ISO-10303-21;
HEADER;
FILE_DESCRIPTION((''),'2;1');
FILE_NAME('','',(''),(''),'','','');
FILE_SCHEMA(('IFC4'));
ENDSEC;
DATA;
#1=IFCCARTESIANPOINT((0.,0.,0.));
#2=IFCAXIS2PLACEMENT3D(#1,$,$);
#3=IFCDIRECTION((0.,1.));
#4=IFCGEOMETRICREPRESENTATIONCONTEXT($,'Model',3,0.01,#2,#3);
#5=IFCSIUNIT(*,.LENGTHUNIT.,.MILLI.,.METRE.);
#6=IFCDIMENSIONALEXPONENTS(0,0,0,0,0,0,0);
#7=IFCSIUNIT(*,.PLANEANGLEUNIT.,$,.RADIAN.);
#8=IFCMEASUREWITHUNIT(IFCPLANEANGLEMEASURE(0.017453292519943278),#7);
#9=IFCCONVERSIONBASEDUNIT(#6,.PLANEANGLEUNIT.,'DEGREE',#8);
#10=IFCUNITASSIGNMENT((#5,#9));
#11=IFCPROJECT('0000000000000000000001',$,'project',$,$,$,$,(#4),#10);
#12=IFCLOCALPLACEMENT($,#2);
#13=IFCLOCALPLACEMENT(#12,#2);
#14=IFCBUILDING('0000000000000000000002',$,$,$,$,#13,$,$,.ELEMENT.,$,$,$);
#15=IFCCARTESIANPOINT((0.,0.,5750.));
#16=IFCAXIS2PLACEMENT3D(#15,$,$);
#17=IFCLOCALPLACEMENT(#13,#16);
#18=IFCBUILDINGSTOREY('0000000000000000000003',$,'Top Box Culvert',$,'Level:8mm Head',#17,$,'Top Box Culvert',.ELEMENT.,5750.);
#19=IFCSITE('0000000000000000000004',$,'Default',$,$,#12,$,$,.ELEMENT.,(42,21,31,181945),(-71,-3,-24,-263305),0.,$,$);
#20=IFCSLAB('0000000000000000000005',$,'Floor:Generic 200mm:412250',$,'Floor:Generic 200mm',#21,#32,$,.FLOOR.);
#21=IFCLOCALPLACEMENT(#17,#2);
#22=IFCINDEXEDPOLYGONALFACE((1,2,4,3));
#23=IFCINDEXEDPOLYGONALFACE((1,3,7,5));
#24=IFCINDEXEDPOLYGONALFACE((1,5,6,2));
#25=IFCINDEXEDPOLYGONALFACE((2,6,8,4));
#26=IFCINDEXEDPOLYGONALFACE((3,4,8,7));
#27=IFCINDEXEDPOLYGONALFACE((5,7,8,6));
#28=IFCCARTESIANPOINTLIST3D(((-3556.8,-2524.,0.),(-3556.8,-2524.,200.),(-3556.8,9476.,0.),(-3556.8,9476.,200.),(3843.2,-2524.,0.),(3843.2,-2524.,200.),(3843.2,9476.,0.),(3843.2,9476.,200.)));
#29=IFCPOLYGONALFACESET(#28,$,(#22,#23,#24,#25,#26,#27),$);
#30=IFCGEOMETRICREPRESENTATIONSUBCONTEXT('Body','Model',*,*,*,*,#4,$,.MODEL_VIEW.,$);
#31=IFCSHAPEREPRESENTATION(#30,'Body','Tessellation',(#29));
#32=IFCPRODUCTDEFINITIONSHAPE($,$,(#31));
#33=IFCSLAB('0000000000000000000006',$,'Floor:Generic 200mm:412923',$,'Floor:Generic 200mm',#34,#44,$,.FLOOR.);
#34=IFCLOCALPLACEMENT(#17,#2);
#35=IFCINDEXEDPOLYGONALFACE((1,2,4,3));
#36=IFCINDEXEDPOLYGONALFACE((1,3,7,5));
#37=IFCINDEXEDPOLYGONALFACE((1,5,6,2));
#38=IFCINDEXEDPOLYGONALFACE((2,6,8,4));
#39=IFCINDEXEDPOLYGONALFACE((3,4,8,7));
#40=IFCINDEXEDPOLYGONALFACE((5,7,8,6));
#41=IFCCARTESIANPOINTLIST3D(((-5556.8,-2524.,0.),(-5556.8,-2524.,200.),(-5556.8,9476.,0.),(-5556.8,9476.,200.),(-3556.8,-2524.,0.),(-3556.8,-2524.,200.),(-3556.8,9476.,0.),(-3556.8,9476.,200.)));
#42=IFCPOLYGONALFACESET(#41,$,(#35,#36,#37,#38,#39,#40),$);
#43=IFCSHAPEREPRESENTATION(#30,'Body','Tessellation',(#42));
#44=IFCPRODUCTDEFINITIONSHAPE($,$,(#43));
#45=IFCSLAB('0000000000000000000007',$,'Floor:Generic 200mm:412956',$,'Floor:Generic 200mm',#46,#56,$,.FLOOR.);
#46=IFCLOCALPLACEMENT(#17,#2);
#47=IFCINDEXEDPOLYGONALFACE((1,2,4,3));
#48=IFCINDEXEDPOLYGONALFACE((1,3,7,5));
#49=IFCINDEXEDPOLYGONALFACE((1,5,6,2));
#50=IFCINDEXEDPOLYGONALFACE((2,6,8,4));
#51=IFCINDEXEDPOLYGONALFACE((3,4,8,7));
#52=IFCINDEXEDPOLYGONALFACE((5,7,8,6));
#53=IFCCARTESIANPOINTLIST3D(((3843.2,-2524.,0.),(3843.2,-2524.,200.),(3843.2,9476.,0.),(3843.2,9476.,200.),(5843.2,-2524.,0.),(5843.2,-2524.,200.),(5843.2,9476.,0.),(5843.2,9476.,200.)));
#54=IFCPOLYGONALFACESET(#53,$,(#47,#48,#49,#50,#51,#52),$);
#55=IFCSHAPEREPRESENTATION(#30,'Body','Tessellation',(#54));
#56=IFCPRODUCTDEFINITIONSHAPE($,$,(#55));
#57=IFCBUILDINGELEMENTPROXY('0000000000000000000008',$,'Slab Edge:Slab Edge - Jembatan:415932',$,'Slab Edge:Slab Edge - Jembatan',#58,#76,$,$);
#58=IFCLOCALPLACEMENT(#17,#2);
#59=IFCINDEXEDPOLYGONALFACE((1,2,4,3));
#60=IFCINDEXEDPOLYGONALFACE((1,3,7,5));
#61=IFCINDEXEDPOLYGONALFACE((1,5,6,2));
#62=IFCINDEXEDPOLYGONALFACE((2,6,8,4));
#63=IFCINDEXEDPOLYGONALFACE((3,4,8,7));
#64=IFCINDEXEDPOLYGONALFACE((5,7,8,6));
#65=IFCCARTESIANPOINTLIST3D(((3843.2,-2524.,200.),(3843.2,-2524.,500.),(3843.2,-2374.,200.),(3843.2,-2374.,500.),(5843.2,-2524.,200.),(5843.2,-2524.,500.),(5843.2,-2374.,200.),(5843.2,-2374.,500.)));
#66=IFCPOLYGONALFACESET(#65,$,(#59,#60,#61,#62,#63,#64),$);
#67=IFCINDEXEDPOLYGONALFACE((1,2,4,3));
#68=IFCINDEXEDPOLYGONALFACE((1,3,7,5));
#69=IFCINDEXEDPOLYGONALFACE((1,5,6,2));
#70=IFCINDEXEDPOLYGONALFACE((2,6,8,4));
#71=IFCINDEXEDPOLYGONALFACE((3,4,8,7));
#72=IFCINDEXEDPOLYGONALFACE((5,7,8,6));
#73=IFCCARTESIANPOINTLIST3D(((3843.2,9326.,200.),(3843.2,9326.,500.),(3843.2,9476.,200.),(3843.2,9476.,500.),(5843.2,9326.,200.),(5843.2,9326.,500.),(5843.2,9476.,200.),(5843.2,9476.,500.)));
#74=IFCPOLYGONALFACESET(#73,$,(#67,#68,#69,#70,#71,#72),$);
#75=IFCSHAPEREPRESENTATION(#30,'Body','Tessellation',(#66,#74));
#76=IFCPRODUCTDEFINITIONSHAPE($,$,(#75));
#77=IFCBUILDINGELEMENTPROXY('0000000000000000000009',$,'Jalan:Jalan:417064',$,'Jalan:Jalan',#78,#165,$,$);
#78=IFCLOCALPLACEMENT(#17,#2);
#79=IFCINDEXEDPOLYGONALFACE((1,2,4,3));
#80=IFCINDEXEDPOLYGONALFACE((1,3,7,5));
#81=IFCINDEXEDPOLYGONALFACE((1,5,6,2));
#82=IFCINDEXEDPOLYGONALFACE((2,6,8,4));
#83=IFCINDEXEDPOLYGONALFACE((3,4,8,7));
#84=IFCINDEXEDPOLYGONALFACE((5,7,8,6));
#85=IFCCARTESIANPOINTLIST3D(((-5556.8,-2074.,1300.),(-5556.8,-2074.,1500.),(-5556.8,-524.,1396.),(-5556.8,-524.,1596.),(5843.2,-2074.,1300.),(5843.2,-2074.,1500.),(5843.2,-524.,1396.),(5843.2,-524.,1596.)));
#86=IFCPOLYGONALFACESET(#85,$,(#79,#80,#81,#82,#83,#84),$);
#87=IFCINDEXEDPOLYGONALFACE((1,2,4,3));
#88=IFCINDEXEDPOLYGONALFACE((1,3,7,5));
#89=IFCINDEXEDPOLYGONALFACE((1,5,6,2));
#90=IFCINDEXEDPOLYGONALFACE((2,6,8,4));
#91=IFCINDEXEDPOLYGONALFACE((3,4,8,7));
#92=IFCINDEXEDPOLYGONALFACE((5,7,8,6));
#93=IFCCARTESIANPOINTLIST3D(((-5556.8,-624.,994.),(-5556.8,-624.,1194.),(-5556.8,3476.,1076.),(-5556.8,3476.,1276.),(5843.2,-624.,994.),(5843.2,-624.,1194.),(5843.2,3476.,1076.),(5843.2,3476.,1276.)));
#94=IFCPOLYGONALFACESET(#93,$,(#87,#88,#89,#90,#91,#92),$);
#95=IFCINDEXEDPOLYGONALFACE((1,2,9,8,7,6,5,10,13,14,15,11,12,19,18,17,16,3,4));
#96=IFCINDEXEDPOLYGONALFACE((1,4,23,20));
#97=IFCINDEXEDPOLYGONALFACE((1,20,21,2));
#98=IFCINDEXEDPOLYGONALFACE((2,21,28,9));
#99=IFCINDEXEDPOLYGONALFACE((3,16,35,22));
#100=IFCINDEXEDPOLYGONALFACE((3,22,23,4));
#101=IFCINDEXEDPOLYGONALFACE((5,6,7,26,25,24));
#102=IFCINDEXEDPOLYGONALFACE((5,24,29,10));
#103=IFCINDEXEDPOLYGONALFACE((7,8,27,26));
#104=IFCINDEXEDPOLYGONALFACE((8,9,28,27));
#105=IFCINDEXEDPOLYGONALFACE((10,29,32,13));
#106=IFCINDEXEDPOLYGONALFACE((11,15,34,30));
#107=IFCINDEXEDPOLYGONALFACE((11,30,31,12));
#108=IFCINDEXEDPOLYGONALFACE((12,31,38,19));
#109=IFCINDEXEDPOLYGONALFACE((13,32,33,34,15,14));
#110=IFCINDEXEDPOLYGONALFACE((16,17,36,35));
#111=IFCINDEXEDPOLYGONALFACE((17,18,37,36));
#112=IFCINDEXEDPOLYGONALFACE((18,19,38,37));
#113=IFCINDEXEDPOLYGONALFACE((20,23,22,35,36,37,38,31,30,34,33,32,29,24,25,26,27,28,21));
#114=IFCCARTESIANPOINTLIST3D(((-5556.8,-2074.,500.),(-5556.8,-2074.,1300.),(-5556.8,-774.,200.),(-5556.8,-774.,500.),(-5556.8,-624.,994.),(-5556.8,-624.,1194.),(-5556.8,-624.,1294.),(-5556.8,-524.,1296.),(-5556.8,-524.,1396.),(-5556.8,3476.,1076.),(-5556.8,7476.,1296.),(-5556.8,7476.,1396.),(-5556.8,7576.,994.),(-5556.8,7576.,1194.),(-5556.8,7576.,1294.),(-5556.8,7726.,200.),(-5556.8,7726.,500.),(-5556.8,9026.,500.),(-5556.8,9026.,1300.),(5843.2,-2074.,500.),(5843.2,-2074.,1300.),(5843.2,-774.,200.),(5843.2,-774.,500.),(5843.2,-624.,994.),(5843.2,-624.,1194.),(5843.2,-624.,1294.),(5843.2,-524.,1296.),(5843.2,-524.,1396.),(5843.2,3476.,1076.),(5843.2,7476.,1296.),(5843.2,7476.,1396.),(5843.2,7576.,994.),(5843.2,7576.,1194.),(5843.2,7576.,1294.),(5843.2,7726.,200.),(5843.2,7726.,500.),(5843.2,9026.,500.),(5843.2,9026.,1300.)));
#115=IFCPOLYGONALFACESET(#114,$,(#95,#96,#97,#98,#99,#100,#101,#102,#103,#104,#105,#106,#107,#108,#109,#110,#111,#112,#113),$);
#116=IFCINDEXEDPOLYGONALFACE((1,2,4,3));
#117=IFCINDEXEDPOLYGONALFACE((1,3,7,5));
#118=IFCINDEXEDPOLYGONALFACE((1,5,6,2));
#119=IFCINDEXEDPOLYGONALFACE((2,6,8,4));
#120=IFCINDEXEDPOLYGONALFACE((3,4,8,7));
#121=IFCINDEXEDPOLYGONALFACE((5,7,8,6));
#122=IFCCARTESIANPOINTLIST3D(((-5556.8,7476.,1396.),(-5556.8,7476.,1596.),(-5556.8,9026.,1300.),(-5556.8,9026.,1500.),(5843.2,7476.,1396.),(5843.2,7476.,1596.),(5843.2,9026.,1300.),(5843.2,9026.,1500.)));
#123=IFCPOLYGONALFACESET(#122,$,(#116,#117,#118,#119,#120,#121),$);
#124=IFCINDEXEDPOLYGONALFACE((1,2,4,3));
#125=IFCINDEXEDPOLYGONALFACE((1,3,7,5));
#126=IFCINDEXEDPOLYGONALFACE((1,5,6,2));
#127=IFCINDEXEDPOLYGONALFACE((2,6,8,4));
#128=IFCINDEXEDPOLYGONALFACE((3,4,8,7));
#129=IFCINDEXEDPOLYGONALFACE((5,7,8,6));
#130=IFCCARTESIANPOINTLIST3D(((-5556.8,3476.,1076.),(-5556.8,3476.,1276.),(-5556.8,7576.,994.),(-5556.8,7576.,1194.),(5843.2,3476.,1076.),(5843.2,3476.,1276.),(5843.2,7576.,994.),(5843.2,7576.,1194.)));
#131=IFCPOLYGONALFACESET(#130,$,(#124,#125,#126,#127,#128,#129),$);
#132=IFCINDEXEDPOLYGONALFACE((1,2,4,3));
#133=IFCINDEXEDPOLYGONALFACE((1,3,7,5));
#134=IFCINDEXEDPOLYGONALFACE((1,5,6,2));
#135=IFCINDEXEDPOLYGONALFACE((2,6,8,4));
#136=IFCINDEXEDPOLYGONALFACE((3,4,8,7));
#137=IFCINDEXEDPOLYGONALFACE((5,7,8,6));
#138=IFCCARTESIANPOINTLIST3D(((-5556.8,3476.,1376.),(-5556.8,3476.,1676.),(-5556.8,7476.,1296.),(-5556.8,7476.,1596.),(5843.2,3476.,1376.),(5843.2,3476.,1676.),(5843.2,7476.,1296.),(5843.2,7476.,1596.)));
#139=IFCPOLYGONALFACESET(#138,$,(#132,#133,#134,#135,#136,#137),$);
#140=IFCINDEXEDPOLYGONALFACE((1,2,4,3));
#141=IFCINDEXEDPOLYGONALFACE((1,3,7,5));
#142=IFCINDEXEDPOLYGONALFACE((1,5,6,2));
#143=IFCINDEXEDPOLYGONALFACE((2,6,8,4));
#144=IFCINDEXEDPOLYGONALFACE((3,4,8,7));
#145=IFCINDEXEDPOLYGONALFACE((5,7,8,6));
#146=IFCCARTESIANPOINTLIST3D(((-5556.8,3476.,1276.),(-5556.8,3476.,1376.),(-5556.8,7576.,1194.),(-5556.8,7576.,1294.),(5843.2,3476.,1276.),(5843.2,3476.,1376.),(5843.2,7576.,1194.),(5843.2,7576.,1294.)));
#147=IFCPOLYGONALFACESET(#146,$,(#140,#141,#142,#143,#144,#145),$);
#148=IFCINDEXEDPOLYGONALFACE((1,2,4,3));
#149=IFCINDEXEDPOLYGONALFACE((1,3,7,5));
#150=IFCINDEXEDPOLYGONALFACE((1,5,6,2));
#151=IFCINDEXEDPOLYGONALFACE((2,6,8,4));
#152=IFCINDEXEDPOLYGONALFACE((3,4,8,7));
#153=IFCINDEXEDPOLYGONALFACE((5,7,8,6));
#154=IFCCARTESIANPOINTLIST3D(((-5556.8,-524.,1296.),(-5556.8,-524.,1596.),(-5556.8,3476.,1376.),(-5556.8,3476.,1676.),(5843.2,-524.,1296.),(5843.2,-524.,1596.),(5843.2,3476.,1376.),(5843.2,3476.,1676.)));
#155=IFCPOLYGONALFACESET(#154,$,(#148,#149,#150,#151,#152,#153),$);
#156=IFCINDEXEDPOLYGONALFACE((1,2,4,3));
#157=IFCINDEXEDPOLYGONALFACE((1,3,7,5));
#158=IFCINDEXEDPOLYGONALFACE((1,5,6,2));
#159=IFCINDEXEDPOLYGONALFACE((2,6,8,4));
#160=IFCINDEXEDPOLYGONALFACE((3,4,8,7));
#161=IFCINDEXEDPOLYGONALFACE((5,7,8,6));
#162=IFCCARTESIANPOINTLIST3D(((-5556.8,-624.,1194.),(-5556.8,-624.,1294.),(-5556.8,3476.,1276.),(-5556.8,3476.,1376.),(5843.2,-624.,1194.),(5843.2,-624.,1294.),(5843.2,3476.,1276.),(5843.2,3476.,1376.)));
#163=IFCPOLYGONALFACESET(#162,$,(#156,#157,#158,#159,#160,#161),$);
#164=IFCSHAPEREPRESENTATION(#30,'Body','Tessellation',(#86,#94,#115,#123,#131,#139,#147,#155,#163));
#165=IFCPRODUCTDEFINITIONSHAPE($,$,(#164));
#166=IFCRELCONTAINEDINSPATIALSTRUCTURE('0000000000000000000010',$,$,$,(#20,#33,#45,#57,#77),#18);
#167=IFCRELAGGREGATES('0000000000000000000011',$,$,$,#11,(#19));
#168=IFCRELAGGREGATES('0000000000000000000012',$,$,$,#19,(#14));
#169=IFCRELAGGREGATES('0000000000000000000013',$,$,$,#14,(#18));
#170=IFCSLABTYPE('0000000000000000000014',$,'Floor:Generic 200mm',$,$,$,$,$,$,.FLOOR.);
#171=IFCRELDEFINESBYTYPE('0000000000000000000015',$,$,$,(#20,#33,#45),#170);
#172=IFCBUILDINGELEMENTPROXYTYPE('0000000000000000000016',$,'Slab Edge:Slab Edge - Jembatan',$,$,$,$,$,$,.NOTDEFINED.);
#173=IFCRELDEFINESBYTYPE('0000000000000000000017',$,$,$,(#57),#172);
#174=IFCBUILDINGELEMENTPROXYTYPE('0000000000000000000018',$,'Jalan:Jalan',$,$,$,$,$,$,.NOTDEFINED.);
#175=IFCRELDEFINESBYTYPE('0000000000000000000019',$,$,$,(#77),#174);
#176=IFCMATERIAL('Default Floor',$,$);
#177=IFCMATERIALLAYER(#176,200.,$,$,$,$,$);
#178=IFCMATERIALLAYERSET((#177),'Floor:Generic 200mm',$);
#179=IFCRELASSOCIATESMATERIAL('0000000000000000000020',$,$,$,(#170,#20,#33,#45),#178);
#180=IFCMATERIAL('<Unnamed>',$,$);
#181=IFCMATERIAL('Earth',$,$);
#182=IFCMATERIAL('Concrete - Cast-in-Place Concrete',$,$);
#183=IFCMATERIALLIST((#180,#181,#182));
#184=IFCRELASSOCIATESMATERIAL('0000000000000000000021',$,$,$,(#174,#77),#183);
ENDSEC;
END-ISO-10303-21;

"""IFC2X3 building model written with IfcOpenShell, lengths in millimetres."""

from ifc_helpers import new_model, entity, si_unit, converted_unit, direction, frame, frame_2d, origin, origin_2d_with_axis, place, context, subcontext, project, spatial, polyline, rectangle, outline, extrude, source, transform, mapped, material, material_list, layer, layer_set, layer_usage, type_object, type_shapes, element, save


model = new_model("IFC2X3")

# Units and contexts
model_context = context("Model", 3, precision=0.01, world=origin(), true_north=direction((0.0, 1.0)))
body_context = subcontext(model_context, "Body", "Model", "MODEL_VIEW")
ifc_project = project(units=[si_unit("LENGTHUNIT", "METRE", prefix="MILLI"), converted_unit("PLANEANGLEUNIT", "DEGREE", entity("IfcPlaneAngleMeasure", 0.017453292519943278), si_unit("PLANEANGLEUNIT", "RADIAN"), dimensions=[0, 0, 0, 0, 0, 0, 0])], contexts=[model_context])

# Site, building, storey
site_placement = place(None, origin())
site = spatial("IfcSite", under=ifc_project, at=site_placement, Name="Default", CompositionType="ELEMENT", RefLatitude=(42, 21, 31, 181945), RefLongitude=(-71, -3, -24, -263305), RefElevation=0.0)
building_placement = place(site_placement, origin())
building = spatial("IfcBuilding", under=site, at=building_placement, CompositionType="ELEMENT")
storey_placement = place(building_placement, frame((0.0, 0.0, 5750.0)))
storey = spatial("IfcBuildingStorey", under=building, at=storey_placement, Name="Top Box Culvert", ObjectType="Level:8mm Head", LongName="Top Box Culvert", CompositionType="ELEMENT", Elevation=5750.0)

# Slabs
ifc_material_1 = material(Name="Default Floor")
ifc_layer = layer(ifc_material_1, 200.0)
ifc_layer_set = layer_set([ifc_layer], Name="Floor:Generic 200mm")
ifc_layer_usage_1 = layer_usage(ifc_layer_set, "AXIS3", "POSITIVE", 0.0)
slab_type = type_object("IfcSlabType", Name="Floor:Generic 200mm", PredefinedType="FLOOR", material=ifc_layer_set)
slab_1_placement = place(storey_placement, origin())
element("IfcSlab", 1, at=slab_1_placement, inside=storey, type_object=slab_type, material=ifc_layer_usage_1, Name="Floor:Generic 200mm:412250", ObjectType="Floor:Generic 200mm", PredefinedType="FLOOR", context=body_context, shape_type="SweptSolid", body=[
    extrude(rectangle(XDim=12000.0, YDim=7400.0, at=origin_2d_with_axis()), frame((143.2, 3476.0, 200.0), z_axis=(0.0, 0.0, -1.0), x_axis=(0.0, 1.0, 0.0)), (0.0, 0.0, 1.0), 200.0),
])
ifc_layer_usage_2 = layer_usage(ifc_layer_set, "AXIS3", "POSITIVE", 0.0)
slab_2_placement = place(storey_placement, origin())
element("IfcSlab", 2, at=slab_2_placement, inside=storey, type_object=slab_type, material=ifc_layer_usage_2, Name="Floor:Generic 200mm:412923", ObjectType="Floor:Generic 200mm", PredefinedType="FLOOR", context=body_context, shape_type="SweptSolid", body=[
    extrude(rectangle(XDim=12000.0, YDim=2000.0, at=frame_2d((0.0, 0.0), x_axis=(1.0, 0.0))), frame((-4556.8, 3476.0, 200.0), z_axis=(0.0, 0.0, -1.0), x_axis=(0.0, 1.0, 0.0)), (0.0, 0.0, 1.0), 200.0),
])
ifc_layer_usage_3 = layer_usage(ifc_layer_set, "AXIS3", "POSITIVE", 0.0)
slab_3_placement = place(storey_placement, origin())
element("IfcSlab", 3, at=slab_3_placement, inside=storey, type_object=slab_type, material=ifc_layer_usage_3, Name="Floor:Generic 200mm:412956", ObjectType="Floor:Generic 200mm", PredefinedType="FLOOR", context=body_context, shape_type="SweptSolid", body=[
    extrude(rectangle(XDim=12000.0, YDim=2000.0, at=frame_2d((0.0, 0.0), x_axis=(1.0, 0.0))), frame((4843.2, 3476.0, 200.0), z_axis=(0.0, 0.0, -1.0), x_axis=(0.0, 1.0, 0.0)), (0.0, 0.0, 1.0), 200.0),
])

# Building element proxies
building_element_proxy_type_1 = type_object("IfcBuildingElementProxyType", Name="Slab Edge:Slab Edge - Jembatan", PredefinedType="NOTDEFINED")
proxy_1_placement = place(storey_placement, origin())
element("IfcBuildingElementProxy", 4, at=proxy_1_placement, inside=storey, type_object=building_element_proxy_type_1, Name="Slab Edge:Slab Edge - Jembatan:415932", ObjectType="Slab Edge:Slab Edge - Jembatan", context=body_context, shape_type="SweptSolid", body=[
    extrude(rectangle(XDim=2000.0, YDim=150.0, at=frame_2d((0.0, 0.0), x_axis=(1.0, 0.0))), frame((4843.2, -2449.0, 200.0)), (0.0, 0.0, 1.0), 300.0),
    extrude(rectangle(XDim=2000.0, YDim=150.0, at=frame_2d((0.0, 0.0), x_axis=(1.0, 0.0))), frame((4843.2, 9401.0, 200.0), z_axis=(0.0, 0.0, 1.0), x_axis=(-1.0, 0.0, 0.0)), (0.0, 0.0, 1.0), 300.0),
])
ifc_material_2 = material(Name="<Unnamed>")
ifc_material_3 = material(Name="Earth")
ifc_material_4 = material(Name="Concrete - Cast-in-Place Concrete")
ifc_material_list = material_list([ifc_material_2, ifc_material_3, ifc_material_4])
building_element_proxy_type_2 = type_object("IfcBuildingElementProxyType", Name="Jalan:Jalan", PredefinedType="NOTDEFINED", material=ifc_material_list)
shared_shape = source(origin(), body_context, "Body", "SweptSolid", [
    extrude(outline(polyline([(-52.0, -775.0), (148.0, -775.0), (52.0, 775.0), (-148.0, 775.0), (-52.0, -775.0)])), frame((-5556.8, -1299.0, 7198.0), z_axis=(1.0, 0.0, 0.0), x_axis=(0.0, 0.0, 1.0)), (0.0, 0.0, 1.0), 11400.0),
    extrude(outline(polyline([(-2052.4, -100.0), (2048.4, -100.0), (2052.4, 100.0), (-2048.4, 100.0), (-2052.4, -100.0)])), frame((-5556.8, 1426.0, 6885.0), z_axis=(1.0, 0.0, 0.0), x_axis=(0.0, 0.9998, 0.019996)), (0.0, 0.0, 1.0), 11400.0),
    extrude(outline(polyline([(-5550.0, 469.7), (-5550.0, -330.3), (-4000.0, -426.3), (-4000.0, -326.3), (-4100.0, -324.3), (-4100.0, -224.3), (-4100.0, -24.3), (0.0, -106.3), (4100.0, -24.3), (4100.0, -224.3), (4100.0, -324.3), (4000.0, -326.3), (4000.0, -426.3), (5550.0, -330.3), (5550.0, 469.7), (4250.0, 469.7), (4250.0, 769.7), (-4250.0, 769.7), (-4250.0, 469.7), (-5550.0, 469.7)])), frame((-5556.8, 3476.0, 6719.7), z_axis=(-1.0, 0.0, 0.0), x_axis=(0.0, 1.0, 0.0)), (0.0, 0.0, -1.0), 11400.0),
    extrude(outline(polyline([(-770.3, -99.8), (782.7, -99.8), (770.3, 99.8), (-782.7, 99.8), (-770.3, -99.8)])), frame((-5556.8, 8251.0, 7198.0), z_axis=(1.0, 0.0, 0.0), x_axis=(0.0, 0.998088, -0.061816)), (0.0, 0.0, 1.0), 11400.0),
    extrude(outline(polyline([(-141.0, -2050.0), (59.0, -2050.0), (141.0, 2050.0), (-59.0, 2050.0), (-141.0, -2050.0)])), frame((-5556.8, 5526.0, 6885.0), z_axis=(1.0, 0.0, 0.0), x_axis=(0.0, 0.0, 1.0)), (0.0, 0.0, 1.0), 11400.0),
    extrude(outline(polyline([(-190.0, -2000.0), (110.0, -2000.0), (190.0, 2000.0), (-110.0, 2000.0), (-190.0, -2000.0)])), frame((-5556.8, 5476.0, 7236.0), z_axis=(1.0, 0.0, 0.0), x_axis=(0.0, 0.0, 1.0)), (0.0, 0.0, 1.0), 11400.0),
    extrude(outline(polyline([(-2049.4, -50.0), (2051.4, -50.0), (2049.4, 50.0), (-2051.4, 50.0), (-2049.4, -50.0)])), frame((-5556.8, 5526.0, 7035.0), z_axis=(1.0, 0.0, 0.0), x_axis=(0.0, -0.9998, 0.019996)), (0.0, 0.0, 1.0), 11400.0),
    extrude(outline(polyline([(-2003.4, -150.0), (1997.4, -150.0), (2003.4, 150.0), (-1997.4, 150.0), (-2003.4, -150.0)])), frame((-5556.8, 1476.0, 7236.0), z_axis=(1.0, 0.0, 0.0), x_axis=(0.0, 0.9998, 0.019996)), (0.0, 0.0, 1.0), 11400.0),
    extrude(outline(polyline([(-9.0, -2050.0), (91.0, -2050.0), (9.0, 2050.0), (-91.0, 2050.0), (-9.0, -2050.0)])), frame((-5556.8, 1426.0, 7035.0), z_axis=(1.0, 0.0, 0.0), x_axis=(0.0, 0.0, -1.0)), (0.0, 0.0, 1.0), 11400.0),
])
type_shapes(building_element_proxy_type_2, [shared_shape])
proxy_2_placement = place(storey_placement, frame((0.0, 0.0, -5750.0)))
element("IfcBuildingElementProxy", 5, at=proxy_2_placement, inside=storey, type_object=building_element_proxy_type_2, material=ifc_material_list, Name="Jalan:Jalan:417064", ObjectType="Jalan:Jalan", context=body_context, shape_type="MappedRepresentation", body=[
    mapped(shared_shape, transform((0.0, 0.0, 0.0), scale=1.0)),
])

save(model, "model.ifc")
